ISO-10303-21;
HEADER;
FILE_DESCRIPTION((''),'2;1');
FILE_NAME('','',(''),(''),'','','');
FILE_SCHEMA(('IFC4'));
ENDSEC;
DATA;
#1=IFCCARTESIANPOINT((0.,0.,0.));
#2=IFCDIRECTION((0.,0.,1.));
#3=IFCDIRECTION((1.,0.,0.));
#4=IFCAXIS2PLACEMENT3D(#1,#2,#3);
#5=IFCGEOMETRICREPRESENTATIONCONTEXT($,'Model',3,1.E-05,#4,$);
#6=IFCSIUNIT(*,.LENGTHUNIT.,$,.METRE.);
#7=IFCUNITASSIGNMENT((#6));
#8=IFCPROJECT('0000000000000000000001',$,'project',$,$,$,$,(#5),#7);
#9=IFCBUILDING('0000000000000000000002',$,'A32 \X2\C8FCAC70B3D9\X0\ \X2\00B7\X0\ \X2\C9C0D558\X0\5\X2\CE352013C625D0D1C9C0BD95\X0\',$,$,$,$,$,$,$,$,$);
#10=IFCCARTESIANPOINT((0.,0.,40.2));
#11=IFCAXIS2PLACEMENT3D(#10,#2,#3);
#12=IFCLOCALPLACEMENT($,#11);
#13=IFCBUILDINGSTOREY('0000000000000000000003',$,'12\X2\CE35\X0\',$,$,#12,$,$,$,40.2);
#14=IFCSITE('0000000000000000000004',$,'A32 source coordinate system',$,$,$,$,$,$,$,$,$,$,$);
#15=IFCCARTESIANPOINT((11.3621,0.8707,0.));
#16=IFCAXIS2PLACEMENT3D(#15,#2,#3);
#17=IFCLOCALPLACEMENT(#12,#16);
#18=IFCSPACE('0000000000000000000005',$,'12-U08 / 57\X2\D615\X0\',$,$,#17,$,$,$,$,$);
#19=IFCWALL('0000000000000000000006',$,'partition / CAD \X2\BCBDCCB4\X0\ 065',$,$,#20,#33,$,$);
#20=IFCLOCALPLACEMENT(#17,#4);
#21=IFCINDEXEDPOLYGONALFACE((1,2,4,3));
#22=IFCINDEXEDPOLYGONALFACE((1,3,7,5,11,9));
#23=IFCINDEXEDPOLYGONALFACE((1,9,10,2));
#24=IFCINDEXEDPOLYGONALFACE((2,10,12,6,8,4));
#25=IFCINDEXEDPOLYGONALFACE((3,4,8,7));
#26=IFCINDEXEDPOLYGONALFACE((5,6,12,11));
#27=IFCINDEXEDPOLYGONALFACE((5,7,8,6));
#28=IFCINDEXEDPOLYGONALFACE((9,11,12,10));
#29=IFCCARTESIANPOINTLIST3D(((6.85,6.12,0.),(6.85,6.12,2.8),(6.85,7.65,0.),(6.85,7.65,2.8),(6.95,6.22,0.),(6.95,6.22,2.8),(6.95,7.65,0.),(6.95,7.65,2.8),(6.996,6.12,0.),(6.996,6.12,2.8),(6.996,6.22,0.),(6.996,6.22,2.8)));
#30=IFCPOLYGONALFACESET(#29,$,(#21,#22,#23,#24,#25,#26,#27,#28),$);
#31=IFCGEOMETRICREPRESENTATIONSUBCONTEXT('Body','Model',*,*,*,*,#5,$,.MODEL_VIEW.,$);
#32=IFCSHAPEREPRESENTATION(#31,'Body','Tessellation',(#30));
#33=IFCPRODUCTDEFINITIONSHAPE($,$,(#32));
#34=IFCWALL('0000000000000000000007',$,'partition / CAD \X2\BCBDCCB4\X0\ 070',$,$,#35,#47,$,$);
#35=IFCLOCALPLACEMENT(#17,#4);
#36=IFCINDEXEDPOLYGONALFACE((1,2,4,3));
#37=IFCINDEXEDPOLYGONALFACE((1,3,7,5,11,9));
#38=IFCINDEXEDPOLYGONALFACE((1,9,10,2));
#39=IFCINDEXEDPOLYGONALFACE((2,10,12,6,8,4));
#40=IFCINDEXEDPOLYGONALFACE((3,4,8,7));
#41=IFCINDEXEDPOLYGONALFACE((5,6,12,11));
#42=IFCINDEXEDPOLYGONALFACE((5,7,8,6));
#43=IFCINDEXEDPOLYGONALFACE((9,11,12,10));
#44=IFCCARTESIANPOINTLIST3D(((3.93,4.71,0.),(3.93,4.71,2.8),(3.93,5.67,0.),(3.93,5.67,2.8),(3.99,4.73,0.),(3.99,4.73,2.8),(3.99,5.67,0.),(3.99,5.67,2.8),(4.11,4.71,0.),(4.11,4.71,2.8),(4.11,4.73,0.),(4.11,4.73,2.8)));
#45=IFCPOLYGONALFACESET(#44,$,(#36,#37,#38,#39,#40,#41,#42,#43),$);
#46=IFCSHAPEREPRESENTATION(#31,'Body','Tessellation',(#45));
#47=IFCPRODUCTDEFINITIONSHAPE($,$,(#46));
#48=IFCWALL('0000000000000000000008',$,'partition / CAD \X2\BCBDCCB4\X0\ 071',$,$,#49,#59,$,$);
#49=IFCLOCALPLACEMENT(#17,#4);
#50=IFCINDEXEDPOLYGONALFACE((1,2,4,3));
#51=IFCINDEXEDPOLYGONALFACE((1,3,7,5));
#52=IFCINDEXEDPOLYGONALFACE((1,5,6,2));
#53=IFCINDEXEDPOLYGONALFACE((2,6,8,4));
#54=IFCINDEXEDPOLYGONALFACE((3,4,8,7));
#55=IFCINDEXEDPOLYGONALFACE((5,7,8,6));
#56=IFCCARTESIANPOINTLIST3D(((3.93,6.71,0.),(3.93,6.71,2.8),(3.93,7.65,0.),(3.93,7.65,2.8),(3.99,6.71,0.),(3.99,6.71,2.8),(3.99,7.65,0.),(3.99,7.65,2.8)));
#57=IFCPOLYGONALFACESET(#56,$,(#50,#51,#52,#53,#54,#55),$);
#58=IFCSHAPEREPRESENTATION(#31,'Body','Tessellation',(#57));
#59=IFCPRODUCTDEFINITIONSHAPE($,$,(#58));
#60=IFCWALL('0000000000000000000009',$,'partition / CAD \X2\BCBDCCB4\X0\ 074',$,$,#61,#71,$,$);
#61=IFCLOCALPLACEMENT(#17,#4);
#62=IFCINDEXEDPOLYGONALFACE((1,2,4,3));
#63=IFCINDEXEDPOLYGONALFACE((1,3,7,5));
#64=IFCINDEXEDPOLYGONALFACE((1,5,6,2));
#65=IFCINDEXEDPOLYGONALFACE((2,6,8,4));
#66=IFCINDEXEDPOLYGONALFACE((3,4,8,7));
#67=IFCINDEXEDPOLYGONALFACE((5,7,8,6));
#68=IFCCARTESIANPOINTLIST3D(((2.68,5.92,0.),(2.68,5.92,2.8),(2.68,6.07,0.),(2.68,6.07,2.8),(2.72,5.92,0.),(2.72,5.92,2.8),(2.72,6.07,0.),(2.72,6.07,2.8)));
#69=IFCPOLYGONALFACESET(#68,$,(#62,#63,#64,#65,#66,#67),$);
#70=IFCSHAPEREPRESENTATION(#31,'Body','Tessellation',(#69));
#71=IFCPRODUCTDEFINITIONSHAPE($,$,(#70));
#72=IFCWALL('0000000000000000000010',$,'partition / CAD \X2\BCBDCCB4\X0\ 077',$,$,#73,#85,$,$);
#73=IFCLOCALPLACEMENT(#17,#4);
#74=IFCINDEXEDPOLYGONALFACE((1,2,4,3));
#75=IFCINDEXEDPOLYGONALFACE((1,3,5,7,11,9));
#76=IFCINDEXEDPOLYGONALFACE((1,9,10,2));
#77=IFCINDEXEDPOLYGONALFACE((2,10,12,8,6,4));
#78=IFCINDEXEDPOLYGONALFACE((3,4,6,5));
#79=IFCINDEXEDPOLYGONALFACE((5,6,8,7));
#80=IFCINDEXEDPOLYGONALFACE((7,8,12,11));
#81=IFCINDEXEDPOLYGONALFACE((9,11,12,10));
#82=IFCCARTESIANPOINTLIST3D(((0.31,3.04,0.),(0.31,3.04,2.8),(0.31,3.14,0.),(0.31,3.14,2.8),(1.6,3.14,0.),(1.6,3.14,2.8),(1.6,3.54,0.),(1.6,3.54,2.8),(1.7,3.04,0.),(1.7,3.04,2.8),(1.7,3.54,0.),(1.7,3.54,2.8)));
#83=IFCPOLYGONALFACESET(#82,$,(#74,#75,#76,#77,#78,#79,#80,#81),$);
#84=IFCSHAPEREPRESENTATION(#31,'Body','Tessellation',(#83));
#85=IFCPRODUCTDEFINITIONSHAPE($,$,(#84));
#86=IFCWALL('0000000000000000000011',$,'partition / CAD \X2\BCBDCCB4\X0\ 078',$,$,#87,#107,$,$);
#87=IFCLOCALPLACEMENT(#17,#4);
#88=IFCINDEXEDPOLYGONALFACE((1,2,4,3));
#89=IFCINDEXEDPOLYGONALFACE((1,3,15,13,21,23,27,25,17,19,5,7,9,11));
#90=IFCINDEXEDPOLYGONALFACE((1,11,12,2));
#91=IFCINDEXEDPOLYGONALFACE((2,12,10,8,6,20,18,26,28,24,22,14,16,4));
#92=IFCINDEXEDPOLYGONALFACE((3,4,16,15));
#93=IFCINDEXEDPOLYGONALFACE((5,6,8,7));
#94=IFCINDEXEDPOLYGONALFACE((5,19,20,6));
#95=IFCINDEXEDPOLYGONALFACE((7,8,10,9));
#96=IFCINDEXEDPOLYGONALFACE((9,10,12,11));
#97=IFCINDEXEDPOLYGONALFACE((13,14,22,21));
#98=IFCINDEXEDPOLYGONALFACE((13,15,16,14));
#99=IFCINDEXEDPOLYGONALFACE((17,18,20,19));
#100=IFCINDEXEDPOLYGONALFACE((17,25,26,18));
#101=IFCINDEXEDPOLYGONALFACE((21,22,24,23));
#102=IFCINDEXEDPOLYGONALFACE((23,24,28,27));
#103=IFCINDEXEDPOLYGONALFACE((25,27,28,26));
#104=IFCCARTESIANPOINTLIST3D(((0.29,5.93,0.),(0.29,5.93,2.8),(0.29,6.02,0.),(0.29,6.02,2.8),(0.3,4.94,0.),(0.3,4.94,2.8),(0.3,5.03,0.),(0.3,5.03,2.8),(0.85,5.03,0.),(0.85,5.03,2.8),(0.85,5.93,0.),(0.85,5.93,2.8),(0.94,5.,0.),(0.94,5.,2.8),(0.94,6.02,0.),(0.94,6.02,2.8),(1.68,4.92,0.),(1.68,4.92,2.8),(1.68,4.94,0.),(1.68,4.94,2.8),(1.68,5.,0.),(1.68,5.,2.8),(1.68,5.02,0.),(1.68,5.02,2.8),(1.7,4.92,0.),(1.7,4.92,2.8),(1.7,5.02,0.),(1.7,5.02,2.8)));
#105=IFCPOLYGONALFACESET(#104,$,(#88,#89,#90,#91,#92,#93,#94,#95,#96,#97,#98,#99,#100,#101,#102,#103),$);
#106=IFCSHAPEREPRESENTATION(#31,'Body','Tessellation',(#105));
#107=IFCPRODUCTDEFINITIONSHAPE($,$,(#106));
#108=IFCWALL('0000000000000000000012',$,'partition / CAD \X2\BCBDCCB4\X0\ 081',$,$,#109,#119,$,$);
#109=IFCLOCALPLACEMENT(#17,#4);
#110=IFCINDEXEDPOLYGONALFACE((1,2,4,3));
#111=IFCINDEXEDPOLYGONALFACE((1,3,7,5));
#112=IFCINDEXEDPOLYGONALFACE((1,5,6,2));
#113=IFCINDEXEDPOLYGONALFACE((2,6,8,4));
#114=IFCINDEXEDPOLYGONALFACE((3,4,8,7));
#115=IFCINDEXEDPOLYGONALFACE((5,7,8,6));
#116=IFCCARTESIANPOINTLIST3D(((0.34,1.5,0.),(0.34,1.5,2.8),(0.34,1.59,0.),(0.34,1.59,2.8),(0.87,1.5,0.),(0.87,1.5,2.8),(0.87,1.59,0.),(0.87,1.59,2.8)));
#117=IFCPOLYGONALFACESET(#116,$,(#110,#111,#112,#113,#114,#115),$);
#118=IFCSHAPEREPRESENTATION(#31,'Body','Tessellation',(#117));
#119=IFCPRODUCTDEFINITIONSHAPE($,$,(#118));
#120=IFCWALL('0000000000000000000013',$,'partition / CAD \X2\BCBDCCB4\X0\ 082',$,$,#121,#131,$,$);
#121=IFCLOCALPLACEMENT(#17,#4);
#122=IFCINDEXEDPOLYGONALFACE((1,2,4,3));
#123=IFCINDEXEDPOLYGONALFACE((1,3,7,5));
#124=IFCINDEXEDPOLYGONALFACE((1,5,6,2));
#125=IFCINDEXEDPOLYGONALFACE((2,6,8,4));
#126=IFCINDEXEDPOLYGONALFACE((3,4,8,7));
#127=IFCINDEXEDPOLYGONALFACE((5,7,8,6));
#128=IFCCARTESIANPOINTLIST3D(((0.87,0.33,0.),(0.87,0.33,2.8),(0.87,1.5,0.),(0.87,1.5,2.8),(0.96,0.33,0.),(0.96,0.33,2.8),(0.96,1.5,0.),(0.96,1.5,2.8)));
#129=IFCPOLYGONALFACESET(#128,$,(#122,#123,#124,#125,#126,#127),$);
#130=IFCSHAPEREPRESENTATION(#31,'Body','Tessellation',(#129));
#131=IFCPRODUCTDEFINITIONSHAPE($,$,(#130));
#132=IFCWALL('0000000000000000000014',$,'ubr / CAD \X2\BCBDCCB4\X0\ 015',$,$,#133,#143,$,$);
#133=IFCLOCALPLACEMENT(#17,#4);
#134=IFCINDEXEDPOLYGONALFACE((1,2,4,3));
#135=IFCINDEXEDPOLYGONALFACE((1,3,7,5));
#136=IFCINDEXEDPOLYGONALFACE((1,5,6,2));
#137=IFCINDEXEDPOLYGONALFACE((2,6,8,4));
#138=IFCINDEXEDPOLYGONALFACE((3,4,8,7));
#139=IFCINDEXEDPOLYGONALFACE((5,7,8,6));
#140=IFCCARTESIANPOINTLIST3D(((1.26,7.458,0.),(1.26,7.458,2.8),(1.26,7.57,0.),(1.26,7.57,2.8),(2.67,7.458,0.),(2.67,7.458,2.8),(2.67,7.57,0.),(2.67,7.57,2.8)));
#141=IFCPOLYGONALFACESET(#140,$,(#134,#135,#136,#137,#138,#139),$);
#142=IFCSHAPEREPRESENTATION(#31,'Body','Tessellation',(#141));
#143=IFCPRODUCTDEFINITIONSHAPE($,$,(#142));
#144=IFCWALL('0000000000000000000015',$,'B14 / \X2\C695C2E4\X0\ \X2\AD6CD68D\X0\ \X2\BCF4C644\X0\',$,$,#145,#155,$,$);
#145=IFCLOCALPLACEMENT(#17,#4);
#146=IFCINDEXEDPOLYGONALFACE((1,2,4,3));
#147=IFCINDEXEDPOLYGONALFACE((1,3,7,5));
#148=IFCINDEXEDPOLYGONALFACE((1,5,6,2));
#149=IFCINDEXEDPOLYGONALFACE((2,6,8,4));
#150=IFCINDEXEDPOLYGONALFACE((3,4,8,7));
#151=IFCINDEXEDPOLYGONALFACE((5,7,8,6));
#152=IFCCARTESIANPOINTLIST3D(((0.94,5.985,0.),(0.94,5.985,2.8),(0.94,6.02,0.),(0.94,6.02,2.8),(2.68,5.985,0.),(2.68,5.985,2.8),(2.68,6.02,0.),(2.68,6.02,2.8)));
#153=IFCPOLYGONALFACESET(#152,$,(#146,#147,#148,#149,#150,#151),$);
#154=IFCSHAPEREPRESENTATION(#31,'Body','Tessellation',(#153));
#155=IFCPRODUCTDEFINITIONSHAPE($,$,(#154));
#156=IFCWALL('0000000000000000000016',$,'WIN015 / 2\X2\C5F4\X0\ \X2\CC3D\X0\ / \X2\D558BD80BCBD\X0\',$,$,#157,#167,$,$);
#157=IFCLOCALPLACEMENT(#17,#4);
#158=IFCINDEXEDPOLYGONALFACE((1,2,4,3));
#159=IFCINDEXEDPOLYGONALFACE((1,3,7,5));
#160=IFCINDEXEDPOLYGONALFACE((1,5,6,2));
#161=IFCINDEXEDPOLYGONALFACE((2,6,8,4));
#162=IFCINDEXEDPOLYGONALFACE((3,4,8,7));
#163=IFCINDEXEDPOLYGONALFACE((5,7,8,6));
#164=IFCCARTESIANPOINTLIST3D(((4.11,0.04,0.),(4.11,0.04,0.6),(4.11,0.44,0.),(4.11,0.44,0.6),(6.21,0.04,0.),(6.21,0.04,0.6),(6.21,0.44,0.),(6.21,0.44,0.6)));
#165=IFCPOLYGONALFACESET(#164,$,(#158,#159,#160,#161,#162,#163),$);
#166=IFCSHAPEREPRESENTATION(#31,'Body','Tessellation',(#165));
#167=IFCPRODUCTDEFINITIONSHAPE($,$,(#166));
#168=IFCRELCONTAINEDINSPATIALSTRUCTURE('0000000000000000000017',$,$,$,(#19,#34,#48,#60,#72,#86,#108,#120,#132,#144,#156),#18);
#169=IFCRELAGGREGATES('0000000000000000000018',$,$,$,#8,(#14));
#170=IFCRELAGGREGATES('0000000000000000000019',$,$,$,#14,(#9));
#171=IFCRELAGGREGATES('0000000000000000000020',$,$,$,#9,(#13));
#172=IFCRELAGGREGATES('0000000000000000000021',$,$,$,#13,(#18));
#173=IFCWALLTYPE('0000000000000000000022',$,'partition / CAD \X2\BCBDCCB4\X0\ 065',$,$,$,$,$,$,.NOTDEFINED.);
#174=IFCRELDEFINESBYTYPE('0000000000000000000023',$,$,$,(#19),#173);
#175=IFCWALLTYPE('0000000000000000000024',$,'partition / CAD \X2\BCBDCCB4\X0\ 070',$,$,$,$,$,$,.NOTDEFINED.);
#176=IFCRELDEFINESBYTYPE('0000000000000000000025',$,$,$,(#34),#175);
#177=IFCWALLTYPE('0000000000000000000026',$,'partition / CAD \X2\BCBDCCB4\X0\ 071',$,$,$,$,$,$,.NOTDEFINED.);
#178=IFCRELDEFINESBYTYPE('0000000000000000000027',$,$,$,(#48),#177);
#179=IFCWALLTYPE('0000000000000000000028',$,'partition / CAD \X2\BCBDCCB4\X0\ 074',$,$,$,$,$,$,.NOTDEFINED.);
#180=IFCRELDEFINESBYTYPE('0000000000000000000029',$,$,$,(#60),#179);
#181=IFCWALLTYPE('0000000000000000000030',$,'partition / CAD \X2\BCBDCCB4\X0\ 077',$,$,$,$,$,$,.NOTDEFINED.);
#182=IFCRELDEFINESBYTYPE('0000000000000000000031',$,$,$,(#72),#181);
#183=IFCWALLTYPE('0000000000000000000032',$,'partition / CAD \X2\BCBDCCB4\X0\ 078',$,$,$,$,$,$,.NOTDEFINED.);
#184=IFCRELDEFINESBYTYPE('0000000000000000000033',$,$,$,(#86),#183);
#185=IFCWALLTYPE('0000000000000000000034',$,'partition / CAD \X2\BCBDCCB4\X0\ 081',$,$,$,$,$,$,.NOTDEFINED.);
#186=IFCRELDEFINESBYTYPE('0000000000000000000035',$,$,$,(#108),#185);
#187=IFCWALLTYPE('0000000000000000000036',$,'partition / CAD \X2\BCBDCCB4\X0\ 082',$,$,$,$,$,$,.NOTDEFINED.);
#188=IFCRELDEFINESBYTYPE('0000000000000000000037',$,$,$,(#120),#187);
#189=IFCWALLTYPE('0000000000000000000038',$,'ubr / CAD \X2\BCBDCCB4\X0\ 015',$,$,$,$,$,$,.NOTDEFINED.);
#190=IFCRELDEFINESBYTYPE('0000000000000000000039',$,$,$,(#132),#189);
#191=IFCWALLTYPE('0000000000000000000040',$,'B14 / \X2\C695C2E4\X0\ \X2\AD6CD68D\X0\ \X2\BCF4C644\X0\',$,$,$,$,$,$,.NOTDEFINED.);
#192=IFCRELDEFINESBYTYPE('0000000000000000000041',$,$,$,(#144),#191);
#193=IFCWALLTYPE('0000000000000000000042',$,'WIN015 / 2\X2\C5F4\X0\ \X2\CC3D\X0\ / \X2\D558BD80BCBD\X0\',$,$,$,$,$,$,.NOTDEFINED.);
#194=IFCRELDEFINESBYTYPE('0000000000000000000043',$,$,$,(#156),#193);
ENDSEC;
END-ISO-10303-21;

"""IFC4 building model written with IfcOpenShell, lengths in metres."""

from ifc_helpers import new_model, si_unit, frame, origin, origin_with_axes, place, context, subcontext, project, spatial, polyline, outline, extrude, source, transform, mapped, type_object, type_shapes, element, save


model = new_model("IFC4")

# Units and contexts
model_context = context("Model", 3, precision=1e-05, world=origin_with_axes())
body_context = subcontext(model_context, "Body", "Model", "MODEL_VIEW")
ifc_project = project(units=[si_unit("LENGTHUNIT", "METRE")], contexts=[model_context])

# Site, building, storey, space
storey_placement = place(None, frame((0.0, 0.0, 40.2), z_axis=(0.0, 0.0, 1.0), x_axis=(1.0, 0.0, 0.0)))
space_placement = place(storey_placement, frame((11.3621, 0.8707, 0.0), z_axis=(0.0, 0.0, 1.0), x_axis=(1.0, 0.0, 0.0)))
site = spatial("IfcSite", under=ifc_project, Name="A32 source coordinate system")
building = spatial("IfcBuilding", under=site, Name="A32 주거동 · 지하5층–옥탑지붕")
storey = spatial("IfcBuildingStorey", under=building, at=storey_placement, Name="12층", Elevation=40.2)
space = spatial("IfcSpace", under=storey, at=space_placement, Name="12-U08 / 57형")

# Walls
wall_type_1 = type_object("IfcWallType", Name="partition / CAD 벽체 065", PredefinedType="NOTDEFINED")
shared_shape_1 = source(origin(), body_context, "Body", "SweptSolid", [
    extrude(outline(polyline([(6.95, 7.65), (6.95, 6.22), (6.996, 6.22), (6.996, 6.12), (6.85, 6.12), (6.85, 7.65), (6.95, 7.65)])), origin(), (0.0, 0.0, 1.0), 2.8),
])
type_shapes(wall_type_1, [shared_shape_1])
wall_1_placement = place(space_placement, origin_with_axes())
element("IfcWall", 1, at=wall_1_placement, inside=space, type_object=wall_type_1, Name="partition / CAD 벽체 065", context=body_context, shape_type="MappedRepresentation", body=[
    mapped(shared_shape_1, transform((0.0, 0.0, 0.0), scale=1.0)),
])
wall_type_2 = type_object("IfcWallType", Name="partition / CAD 벽체 070", PredefinedType="NOTDEFINED")
shared_shape_2 = source(origin(), body_context, "Body", "SweptSolid", [
    extrude(outline(polyline([(4.11, 4.73), (4.11, 4.71), (3.93, 4.71), (3.93, 5.67), (3.99, 5.67), (3.99, 4.73), (4.11, 4.73)])), origin(), (0.0, 0.0, 1.0), 2.8),
])
type_shapes(wall_type_2, [shared_shape_2])
wall_2_placement = place(space_placement, origin_with_axes())
element("IfcWall", 2, at=wall_2_placement, inside=space, type_object=wall_type_2, Name="partition / CAD 벽체 070", context=body_context, shape_type="MappedRepresentation", body=[
    mapped(shared_shape_2, transform((0.0, 0.0, 0.0), scale=1.0)),
])
wall_type_3 = type_object("IfcWallType", Name="partition / CAD 벽체 071", PredefinedType="NOTDEFINED")
shared_shape_3 = source(origin(), body_context, "Body", "SweptSolid", [
    extrude(outline(polyline([(3.93, 6.71), (3.93, 7.65), (3.99, 7.65), (3.99, 6.71), (3.93, 6.71)])), origin(), (0.0, 0.0, 1.0), 2.8),
])
type_shapes(wall_type_3, [shared_shape_3])
wall_3_placement = place(space_placement, origin_with_axes())
element("IfcWall", 3, at=wall_3_placement, inside=space, type_object=wall_type_3, Name="partition / CAD 벽체 071", context=body_context, shape_type="MappedRepresentation", body=[
    mapped(shared_shape_3, transform((0.0, 0.0, 0.0), scale=1.0)),
])
wall_type_4 = type_object("IfcWallType", Name="partition / CAD 벽체 074", PredefinedType="NOTDEFINED")
shared_shape_4 = source(origin(), body_context, "Body", "SweptSolid", [
    extrude(outline(polyline([(2.72, 6.07), (2.72, 5.92), (2.68, 5.92), (2.68, 6.07), (2.72, 6.07)])), origin(), (0.0, 0.0, 1.0), 2.8),
])
type_shapes(wall_type_4, [shared_shape_4])
wall_4_placement = place(space_placement, origin_with_axes())
element("IfcWall", 4, at=wall_4_placement, inside=space, type_object=wall_type_4, Name="partition / CAD 벽체 074", context=body_context, shape_type="MappedRepresentation", body=[
    mapped(shared_shape_4, transform((0.0, 0.0, 0.0), scale=1.0)),
])
wall_type_5 = type_object("IfcWallType", Name="partition / CAD 벽체 077", PredefinedType="NOTDEFINED")
shared_shape_5 = source(origin(), body_context, "Body", "SweptSolid", [
    extrude(outline(polyline([(1.7, 3.54), (1.7, 3.04), (0.31, 3.04), (0.31, 3.14), (1.6, 3.14), (1.6, 3.54), (1.7, 3.54)])), origin(), (0.0, 0.0, 1.0), 2.8),
])
type_shapes(wall_type_5, [shared_shape_5])
wall_5_placement = place(space_placement, origin_with_axes())
element("IfcWall", 5, at=wall_5_placement, inside=space, type_object=wall_type_5, Name="partition / CAD 벽체 077", context=body_context, shape_type="MappedRepresentation", body=[
    mapped(shared_shape_5, transform((0.0, 0.0, 0.0), scale=1.0)),
])
wall_type_6 = type_object("IfcWallType", Name="partition / CAD 벽체 078", PredefinedType="NOTDEFINED")
shared_shape_6 = source(origin(), body_context, "Body", "SweptSolid", [
    extrude(outline(polyline([(1.7, 4.92), (1.68, 4.92), (1.68, 4.94), (0.3, 4.94), (0.3, 5.03), (0.85, 5.03), (0.85, 5.93), (0.29, 5.93), (0.29, 6.02), (0.94, 6.02), (0.94, 5.0), (1.68, 5.0), (1.68, 5.02), (1.7, 5.02), (1.7, 4.92)])), origin(), (0.0, 0.0, 1.0), 2.8),
])
type_shapes(wall_type_6, [shared_shape_6])
wall_6_placement = place(space_placement, origin_with_axes())
element("IfcWall", 6, at=wall_6_placement, inside=space, type_object=wall_type_6, Name="partition / CAD 벽체 078", context=body_context, shape_type="MappedRepresentation", body=[
    mapped(shared_shape_6, transform((0.0, 0.0, 0.0), scale=1.0)),
])
wall_type_7 = type_object("IfcWallType", Name="partition / CAD 벽체 081", PredefinedType="NOTDEFINED")
shared_shape_7 = source(origin(), body_context, "Body", "SweptSolid", [
    extrude(outline(polyline([(0.34, 1.59), (0.87, 1.59), (0.87, 1.5), (0.34, 1.5), (0.34, 1.59)])), origin(), (0.0, 0.0, 1.0), 2.8),
])
type_shapes(wall_type_7, [shared_shape_7])
wall_7_placement = place(space_placement, origin_with_axes())
element("IfcWall", 7, at=wall_7_placement, inside=space, type_object=wall_type_7, Name="partition / CAD 벽체 081", context=body_context, shape_type="MappedRepresentation", body=[
    mapped(shared_shape_7, transform((0.0, 0.0, 0.0), scale=1.0)),
])
wall_type_8 = type_object("IfcWallType", Name="partition / CAD 벽체 082", PredefinedType="NOTDEFINED")
shared_shape_8 = source(origin(), body_context, "Body", "SweptSolid", [
    extrude(outline(polyline([(0.96, 0.33), (0.87, 0.33), (0.87, 1.5), (0.96, 1.5), (0.96, 0.33)])), origin(), (0.0, 0.0, 1.0), 2.8),
])
type_shapes(wall_type_8, [shared_shape_8])
wall_8_placement = place(space_placement, origin_with_axes())
element("IfcWall", 8, at=wall_8_placement, inside=space, type_object=wall_type_8, Name="partition / CAD 벽체 082", context=body_context, shape_type="MappedRepresentation", body=[
    mapped(shared_shape_8, transform((0.0, 0.0, 0.0), scale=1.0)),
])
wall_type_9 = type_object("IfcWallType", Name="ubr / CAD 벽체 015", PredefinedType="NOTDEFINED")
shared_shape_9 = source(origin(), body_context, "Body", "SweptSolid", [
    extrude(outline(polyline([(2.67, 7.57), (2.67, 7.458), (1.26, 7.458), (1.26, 7.57), (2.67, 7.57)])), origin(), (0.0, 0.0, 1.0), 2.8),
])
type_shapes(wall_type_9, [shared_shape_9])
wall_9_placement = place(space_placement, origin_with_axes())
element("IfcWall", 9, at=wall_9_placement, inside=space, type_object=wall_type_9, Name="ubr / CAD 벽체 015", context=body_context, shape_type="MappedRepresentation", body=[
    mapped(shared_shape_9, transform((0.0, 0.0, 0.0), scale=1.0)),
])
wall_type_10 = type_object("IfcWallType", Name="B14 / 욕실 구획 보완", PredefinedType="NOTDEFINED")
shared_shape_10 = source(origin(), body_context, "Body", "SweptSolid", [
    extrude(outline(polyline([(2.68, 5.985), (0.94, 5.985), (0.94, 6.02), (2.68, 6.02), (2.68, 5.985)])), origin(), (0.0, 0.0, 1.0), 2.8),
])
type_shapes(wall_type_10, [shared_shape_10])
wall_10_placement = place(space_placement, origin_with_axes())
element("IfcWall", 10, at=wall_10_placement, inside=space, type_object=wall_type_10, Name="B14 / 욕실 구획 보완", context=body_context, shape_type="MappedRepresentation", body=[
    mapped(shared_shape_10, transform((0.0, 0.0, 0.0), scale=1.0)),
])
wall_type_11 = type_object("IfcWallType", Name="WIN015 / 2열 창 / 하부벽", PredefinedType="NOTDEFINED")
shared_shape_11 = source(origin(), body_context, "Body", "SweptSolid", [
    extrude(outline(polyline([(4.11, 0.04), (4.11, 0.44), (6.21, 0.44), (6.21, 0.04), (4.11, 0.04)])), origin(), (0.0, 0.0, 1.0), 0.6),
])
type_shapes(wall_type_11, [shared_shape_11])
wall_11_placement = place(space_placement, origin_with_axes())
element("IfcWall", 11, at=wall_11_placement, inside=space, type_object=wall_type_11, Name="WIN015 / 2열 창 / 하부벽", context=body_context, shape_type="MappedRepresentation", body=[
    mapped(shared_shape_11, transform((0.0, 0.0, 0.0), scale=1.0)),
])

save(model, "model.ifc")
